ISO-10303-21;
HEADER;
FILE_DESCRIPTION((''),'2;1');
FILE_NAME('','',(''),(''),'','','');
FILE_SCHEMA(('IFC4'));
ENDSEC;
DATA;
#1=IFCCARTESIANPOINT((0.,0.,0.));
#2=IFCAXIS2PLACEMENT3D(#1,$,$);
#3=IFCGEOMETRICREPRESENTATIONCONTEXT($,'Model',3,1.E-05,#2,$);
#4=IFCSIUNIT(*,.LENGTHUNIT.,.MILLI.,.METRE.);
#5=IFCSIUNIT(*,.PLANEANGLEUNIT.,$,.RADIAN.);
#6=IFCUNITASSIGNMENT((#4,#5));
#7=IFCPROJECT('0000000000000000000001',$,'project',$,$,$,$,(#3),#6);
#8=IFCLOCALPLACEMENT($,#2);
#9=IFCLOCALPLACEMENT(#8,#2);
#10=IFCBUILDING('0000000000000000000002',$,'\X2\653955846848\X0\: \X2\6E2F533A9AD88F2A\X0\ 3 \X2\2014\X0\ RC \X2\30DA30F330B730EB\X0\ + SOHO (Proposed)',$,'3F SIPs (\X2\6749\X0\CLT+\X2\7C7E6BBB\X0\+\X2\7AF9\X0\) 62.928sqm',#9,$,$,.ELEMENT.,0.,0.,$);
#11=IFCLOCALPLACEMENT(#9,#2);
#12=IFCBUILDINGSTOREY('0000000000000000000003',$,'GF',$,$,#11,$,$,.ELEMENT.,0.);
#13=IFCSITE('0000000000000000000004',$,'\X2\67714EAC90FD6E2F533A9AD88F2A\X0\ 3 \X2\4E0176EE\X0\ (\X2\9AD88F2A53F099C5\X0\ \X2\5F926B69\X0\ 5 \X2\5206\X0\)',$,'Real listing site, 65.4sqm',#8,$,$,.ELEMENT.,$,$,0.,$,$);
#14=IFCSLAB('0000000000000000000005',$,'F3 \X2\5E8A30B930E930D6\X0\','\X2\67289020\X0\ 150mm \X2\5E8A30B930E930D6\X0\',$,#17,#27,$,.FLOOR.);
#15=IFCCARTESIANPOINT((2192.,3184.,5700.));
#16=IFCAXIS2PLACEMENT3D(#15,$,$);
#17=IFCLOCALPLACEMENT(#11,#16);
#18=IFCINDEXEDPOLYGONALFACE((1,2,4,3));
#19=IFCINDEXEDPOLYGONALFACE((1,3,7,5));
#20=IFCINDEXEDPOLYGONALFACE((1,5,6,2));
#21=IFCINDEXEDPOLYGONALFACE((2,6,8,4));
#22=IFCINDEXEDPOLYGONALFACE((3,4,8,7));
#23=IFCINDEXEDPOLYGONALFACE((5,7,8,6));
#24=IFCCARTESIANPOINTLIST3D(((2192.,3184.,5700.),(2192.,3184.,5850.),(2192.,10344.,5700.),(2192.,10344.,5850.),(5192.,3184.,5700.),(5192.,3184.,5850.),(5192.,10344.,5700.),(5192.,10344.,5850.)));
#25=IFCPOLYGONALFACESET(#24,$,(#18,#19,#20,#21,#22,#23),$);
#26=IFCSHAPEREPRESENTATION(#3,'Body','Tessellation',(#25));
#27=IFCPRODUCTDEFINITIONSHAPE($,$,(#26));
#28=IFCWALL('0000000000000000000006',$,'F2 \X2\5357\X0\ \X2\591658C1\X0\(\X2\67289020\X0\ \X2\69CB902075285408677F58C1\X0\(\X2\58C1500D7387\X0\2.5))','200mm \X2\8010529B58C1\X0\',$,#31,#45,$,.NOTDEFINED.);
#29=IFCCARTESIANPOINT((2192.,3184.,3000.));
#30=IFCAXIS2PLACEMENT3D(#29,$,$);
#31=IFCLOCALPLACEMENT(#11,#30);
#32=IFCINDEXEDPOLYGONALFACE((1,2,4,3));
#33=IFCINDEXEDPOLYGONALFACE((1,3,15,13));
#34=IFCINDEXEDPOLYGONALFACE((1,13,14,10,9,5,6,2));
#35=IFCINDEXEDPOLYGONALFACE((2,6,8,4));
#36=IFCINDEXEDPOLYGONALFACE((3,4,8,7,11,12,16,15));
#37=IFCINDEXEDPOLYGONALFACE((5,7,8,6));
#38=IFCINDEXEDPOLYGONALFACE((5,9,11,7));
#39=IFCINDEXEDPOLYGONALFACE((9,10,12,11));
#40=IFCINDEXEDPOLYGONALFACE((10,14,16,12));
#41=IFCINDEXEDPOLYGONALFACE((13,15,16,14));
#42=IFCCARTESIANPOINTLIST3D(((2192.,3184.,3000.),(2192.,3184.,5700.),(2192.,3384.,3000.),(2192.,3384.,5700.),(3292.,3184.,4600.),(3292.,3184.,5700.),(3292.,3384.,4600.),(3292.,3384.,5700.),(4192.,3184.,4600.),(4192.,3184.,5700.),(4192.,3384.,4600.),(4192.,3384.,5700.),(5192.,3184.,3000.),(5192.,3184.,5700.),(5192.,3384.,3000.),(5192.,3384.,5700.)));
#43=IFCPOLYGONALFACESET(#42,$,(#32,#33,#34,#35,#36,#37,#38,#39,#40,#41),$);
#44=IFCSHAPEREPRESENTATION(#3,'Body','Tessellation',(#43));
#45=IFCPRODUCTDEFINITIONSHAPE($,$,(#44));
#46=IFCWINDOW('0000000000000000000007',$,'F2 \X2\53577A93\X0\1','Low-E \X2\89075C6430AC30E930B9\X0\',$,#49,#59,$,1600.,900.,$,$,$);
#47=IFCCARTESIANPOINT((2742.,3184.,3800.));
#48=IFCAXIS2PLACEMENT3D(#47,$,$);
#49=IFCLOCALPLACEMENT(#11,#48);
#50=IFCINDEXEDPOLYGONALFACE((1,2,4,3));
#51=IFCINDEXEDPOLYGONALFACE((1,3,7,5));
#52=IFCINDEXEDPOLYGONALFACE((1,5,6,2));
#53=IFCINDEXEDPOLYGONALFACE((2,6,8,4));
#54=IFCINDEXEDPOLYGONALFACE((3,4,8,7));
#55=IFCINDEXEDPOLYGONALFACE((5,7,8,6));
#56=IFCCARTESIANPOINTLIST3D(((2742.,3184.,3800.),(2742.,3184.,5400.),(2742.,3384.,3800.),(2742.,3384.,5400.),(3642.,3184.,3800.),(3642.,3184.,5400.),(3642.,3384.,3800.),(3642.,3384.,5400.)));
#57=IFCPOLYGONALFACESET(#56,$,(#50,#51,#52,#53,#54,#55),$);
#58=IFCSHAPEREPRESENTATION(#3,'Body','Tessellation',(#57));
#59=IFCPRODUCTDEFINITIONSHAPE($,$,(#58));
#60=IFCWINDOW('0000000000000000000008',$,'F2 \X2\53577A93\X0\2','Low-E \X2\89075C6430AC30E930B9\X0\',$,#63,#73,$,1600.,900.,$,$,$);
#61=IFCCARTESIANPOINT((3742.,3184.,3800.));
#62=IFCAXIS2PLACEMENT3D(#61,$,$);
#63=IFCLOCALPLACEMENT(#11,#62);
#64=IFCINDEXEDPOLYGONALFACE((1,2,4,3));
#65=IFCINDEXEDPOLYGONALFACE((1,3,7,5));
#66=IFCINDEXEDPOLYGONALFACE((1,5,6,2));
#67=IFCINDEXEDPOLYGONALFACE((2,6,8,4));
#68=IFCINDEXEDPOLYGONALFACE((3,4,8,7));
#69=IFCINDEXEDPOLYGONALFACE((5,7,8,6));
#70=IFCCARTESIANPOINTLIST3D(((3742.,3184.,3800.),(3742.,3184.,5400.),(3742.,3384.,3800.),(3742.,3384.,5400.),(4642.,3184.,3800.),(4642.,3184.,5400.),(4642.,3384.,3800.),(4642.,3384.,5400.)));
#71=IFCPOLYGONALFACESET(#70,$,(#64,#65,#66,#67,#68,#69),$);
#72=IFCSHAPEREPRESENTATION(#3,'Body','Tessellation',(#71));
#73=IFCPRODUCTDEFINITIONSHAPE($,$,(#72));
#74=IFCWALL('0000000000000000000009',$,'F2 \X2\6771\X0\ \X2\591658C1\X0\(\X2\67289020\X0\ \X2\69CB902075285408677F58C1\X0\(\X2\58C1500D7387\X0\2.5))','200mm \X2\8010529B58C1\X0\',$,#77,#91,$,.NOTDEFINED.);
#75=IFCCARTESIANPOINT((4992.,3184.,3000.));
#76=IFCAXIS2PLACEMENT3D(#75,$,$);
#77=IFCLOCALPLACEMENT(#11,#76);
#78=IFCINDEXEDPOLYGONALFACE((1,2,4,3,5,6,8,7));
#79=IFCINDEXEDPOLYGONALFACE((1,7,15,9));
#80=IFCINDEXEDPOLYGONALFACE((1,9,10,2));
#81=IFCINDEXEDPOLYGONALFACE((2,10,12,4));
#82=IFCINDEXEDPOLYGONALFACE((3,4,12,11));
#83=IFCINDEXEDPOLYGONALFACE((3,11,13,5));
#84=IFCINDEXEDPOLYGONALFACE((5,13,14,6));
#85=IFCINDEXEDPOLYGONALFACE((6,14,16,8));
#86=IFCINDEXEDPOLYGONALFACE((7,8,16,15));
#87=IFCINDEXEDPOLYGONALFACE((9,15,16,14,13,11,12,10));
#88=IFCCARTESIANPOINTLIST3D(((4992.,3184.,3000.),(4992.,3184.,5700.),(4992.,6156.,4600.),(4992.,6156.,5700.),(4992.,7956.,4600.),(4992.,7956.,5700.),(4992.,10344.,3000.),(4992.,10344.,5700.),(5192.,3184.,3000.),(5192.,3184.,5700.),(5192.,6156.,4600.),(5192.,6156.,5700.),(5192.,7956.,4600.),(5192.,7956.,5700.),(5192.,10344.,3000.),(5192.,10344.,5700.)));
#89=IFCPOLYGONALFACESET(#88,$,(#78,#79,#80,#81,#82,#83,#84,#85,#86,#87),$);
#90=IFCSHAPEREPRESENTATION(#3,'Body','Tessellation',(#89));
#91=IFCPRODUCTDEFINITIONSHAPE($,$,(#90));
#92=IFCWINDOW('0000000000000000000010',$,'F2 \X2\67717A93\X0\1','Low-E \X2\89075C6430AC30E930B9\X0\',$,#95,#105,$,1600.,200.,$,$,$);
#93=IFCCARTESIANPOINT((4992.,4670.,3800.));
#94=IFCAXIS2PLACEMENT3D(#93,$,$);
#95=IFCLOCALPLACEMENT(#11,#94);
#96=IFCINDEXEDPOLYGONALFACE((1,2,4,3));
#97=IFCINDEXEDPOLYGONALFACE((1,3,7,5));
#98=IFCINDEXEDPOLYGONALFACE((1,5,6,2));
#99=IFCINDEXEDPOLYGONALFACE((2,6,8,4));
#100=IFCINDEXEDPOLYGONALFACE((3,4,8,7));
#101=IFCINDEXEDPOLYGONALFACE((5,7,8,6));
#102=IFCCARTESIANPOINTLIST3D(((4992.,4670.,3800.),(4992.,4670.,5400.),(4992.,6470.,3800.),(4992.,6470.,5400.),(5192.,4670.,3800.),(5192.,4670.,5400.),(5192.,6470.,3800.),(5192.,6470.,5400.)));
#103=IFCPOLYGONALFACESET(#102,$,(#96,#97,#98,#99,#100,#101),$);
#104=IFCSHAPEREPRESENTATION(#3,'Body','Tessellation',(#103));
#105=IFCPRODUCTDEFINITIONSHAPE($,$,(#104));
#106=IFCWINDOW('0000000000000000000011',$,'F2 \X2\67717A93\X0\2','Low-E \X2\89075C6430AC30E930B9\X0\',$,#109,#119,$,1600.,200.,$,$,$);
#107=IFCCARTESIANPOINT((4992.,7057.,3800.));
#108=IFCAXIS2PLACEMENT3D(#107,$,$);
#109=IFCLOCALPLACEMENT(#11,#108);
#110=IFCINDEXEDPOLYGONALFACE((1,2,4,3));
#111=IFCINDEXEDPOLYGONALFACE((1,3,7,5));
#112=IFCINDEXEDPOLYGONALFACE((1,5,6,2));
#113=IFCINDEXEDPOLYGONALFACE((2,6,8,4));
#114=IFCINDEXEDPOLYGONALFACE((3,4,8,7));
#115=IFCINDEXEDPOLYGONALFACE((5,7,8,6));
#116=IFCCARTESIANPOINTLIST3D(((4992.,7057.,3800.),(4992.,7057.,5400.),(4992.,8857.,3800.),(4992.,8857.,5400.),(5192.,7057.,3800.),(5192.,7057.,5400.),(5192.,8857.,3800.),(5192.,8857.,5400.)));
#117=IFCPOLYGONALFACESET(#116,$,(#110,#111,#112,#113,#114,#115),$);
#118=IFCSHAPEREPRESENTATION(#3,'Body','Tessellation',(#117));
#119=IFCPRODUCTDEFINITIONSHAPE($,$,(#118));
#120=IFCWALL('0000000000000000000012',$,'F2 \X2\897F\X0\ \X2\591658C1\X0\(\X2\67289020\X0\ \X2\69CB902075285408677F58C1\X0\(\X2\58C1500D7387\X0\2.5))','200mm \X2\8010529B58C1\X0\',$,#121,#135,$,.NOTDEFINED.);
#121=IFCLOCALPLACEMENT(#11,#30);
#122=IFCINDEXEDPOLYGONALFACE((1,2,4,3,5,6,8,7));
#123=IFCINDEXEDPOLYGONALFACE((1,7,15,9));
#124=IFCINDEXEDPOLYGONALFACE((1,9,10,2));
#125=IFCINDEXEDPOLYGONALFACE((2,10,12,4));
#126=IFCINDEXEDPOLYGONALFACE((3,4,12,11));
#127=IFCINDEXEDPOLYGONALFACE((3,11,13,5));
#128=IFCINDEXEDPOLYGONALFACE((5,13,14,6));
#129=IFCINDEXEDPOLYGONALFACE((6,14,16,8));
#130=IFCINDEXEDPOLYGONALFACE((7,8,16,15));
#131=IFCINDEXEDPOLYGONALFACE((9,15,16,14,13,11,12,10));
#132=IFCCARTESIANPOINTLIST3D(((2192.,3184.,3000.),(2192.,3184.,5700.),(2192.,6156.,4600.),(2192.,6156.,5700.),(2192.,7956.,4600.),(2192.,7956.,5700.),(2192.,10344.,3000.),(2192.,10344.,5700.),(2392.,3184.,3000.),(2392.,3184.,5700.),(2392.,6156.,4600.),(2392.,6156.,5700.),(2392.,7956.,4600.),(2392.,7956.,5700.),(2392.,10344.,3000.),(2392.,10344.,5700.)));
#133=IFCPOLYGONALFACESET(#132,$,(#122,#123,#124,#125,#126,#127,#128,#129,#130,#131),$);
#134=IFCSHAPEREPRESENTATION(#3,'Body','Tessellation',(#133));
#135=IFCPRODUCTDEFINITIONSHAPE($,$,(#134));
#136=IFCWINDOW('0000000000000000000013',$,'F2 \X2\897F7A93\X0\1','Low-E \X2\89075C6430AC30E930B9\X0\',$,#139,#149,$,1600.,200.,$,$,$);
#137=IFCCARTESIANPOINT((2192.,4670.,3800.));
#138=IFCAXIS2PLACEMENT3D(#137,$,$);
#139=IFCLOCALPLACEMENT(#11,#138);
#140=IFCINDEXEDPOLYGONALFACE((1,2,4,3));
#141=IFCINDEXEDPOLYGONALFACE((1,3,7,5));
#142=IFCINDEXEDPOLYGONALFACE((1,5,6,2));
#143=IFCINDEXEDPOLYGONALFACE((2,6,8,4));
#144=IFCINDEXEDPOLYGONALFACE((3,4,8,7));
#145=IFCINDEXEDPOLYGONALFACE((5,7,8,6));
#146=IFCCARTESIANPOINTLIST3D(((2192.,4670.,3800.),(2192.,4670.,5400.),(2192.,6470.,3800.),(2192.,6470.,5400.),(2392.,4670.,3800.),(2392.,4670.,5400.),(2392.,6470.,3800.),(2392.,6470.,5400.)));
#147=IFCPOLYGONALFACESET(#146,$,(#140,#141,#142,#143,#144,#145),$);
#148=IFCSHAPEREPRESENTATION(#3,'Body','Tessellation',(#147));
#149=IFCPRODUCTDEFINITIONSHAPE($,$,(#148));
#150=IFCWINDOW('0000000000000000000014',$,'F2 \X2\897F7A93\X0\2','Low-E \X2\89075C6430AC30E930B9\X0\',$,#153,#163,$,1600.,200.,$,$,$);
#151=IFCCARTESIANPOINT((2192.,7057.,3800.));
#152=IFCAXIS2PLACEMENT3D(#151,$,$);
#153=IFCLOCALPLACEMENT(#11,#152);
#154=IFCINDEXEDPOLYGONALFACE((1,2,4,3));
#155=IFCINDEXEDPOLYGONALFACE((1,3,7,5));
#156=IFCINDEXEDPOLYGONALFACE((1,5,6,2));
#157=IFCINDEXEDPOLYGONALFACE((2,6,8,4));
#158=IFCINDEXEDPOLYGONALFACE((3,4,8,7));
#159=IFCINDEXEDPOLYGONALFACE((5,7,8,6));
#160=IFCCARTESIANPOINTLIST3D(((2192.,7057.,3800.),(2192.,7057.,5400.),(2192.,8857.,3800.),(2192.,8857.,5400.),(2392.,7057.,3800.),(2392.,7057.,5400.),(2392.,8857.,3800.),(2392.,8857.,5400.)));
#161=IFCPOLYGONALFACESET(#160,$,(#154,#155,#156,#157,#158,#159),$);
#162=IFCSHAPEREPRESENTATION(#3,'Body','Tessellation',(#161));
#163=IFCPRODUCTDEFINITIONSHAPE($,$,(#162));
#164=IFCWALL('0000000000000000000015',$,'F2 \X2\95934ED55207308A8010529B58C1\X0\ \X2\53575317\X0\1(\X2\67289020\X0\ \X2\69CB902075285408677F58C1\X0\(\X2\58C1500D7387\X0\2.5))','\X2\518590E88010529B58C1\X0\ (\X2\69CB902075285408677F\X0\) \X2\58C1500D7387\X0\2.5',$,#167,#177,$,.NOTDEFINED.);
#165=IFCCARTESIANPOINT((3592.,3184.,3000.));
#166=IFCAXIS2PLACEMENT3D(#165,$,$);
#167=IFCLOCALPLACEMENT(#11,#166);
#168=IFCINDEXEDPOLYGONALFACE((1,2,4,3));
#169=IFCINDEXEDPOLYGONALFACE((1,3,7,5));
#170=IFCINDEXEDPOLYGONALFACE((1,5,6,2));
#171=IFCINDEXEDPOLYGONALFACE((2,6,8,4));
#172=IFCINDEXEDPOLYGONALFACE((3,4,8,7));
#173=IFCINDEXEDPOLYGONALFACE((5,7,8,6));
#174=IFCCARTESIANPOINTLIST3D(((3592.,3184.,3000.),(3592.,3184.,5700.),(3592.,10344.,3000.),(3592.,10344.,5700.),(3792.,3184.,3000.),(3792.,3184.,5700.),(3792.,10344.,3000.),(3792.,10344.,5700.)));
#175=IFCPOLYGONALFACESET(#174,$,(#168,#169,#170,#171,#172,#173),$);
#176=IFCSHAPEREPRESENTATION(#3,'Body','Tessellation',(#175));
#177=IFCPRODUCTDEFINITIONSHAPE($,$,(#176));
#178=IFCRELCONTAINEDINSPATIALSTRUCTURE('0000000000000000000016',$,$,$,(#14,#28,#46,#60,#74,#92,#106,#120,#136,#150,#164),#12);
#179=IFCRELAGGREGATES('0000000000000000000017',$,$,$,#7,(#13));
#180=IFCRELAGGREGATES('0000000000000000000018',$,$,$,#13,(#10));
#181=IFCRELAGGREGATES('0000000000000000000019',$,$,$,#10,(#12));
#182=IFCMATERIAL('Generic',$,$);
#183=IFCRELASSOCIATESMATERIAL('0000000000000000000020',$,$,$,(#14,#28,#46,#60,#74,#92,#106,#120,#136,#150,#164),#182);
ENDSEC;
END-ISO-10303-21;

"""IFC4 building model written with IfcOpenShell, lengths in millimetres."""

from ifc_helpers import new_model, si_unit, frame, frame_2d, origin, place, context, project, spatial, rectangle, extrude, material, element, fill, save


model = new_model("IFC4")

# Units and contexts
model_context = context("Model", 3, precision=1e-05, world=origin())
ifc_project = project(units=[si_unit("LENGTHUNIT", "METRE", prefix="MILLI"), si_unit("PLANEANGLEUNIT", "RADIAN")], contexts=[model_context])

# Site, building, storey
site_placement = place(None, origin())
site = spatial("IfcSite", under=ifc_project, at=site_placement, Name="東京都港区高輪 3 丁目 (高輪台駅 徒歩 5 分)", ObjectType="Real listing site, 65.4sqm", CompositionType="ELEMENT", RefElevation=0.0)
building_placement = place(site_placement, origin())
building = spatial("IfcBuilding", under=site, at=building_placement, Name="改善案: 港区高輪 3 — RC ペンシル + SOHO (Proposed)", ObjectType="3F SIPs (杉CLT+籾殻+竹) 62.928sqm", CompositionType="ELEMENT", ElevationOfRefHeight=0.0, ElevationOfTerrain=0.0)
storey_placement = place(building_placement, origin())
storey = spatial("IfcBuildingStorey", under=building, at=storey_placement, Name="GF", CompositionType="ELEMENT", Elevation=0.0)

# Slab
ifc_material = material(Name="Generic")
slab_placement = place(storey_placement, frame((2192.0, 3184.0, 5700.0)))
element("IfcSlab", 1, at=slab_placement, inside=storey, material=ifc_material, Name="F3 床スラブ", Description="木造 150mm 床スラブ", PredefinedType="FLOOR", context=model_context, shape_type="SweptSolid", body=[
    extrude(rectangle(XDim=3000.0, YDim=7160.0, at=frame_2d((1500.0, 3580.0))), frame((2192.0, 3184.0, 5700.0)), (0.0, 0.0, 1.0), 150.0),
])

# Walls, openings, windows
wall_1_placement = place(storey_placement, frame((2192.0, 3184.0, 3000.0)))
wall_1 = element("IfcWall", 2, at=wall_1_placement, inside=storey, material=ifc_material, Name="F2 南 外壁(木造 構造用合板壁(壁倍率2.5))", Description="200mm 耐力壁", PredefinedType="NOTDEFINED", context=model_context, shape_type="SweptSolid", body=[
    extrude(rectangle(XDim=3000.0, YDim=200.0, at=frame_2d((1500.0, 100.0))), frame((2192.0, 3184.0, 3000.0)), (0.0, 0.0, 1.0), 2700.0),
])
opening_1_placement = place(storey_placement, frame((2742.0, 3184.0, 3800.0)))
opening_1 = element("IfcOpeningElement", 3, at=opening_1_placement, cuts=wall_1, PredefinedType="NOTDEFINED", context=model_context, shape_type="SweptSolid", body=[
    extrude(rectangle(XDim=900.0, YDim=200.0, at=frame_2d((450.0, 100.0))), frame((2742.0, 3184.0, 3800.0)), (0.0, 0.0, 1.0), 1600.0),
])
opening_2_placement = place(storey_placement, frame((3742.0, 3184.0, 3800.0)))
opening_2 = element("IfcOpeningElement", 4, at=opening_2_placement, cuts=wall_1, PredefinedType="NOTDEFINED", context=model_context, shape_type="SweptSolid", body=[
    extrude(rectangle(XDim=900.0, YDim=200.0, at=frame_2d((450.0, 100.0))), frame((3742.0, 3184.0, 3800.0)), (0.0, 0.0, 1.0), 1600.0),
])
window_1_placement = place(storey_placement, frame((2742.0, 3184.0, 3800.0)))
window_1 = element("IfcWindow", 5, at=window_1_placement, inside=storey, material=ifc_material, Name="F2 南窓1", Description="Low-E 複層ガラス", OverallHeight=1600.0, OverallWidth=900.0, context=model_context, shape_type="SweptSolid", body=[
    extrude(rectangle(XDim=900.0, YDim=200.0, at=frame_2d((450.0, 100.0))), frame((2742.0, 3184.0, 3800.0)), (0.0, 0.0, 1.0), 1600.0),
])
fill(opening_1, window_1)
window_2_placement = place(storey_placement, frame((3742.0, 3184.0, 3800.0)))
window_2 = element("IfcWindow", 6, at=window_2_placement, inside=storey, material=ifc_material, Name="F2 南窓2", Description="Low-E 複層ガラス", OverallHeight=1600.0, OverallWidth=900.0, context=model_context, shape_type="SweptSolid", body=[
    extrude(rectangle(XDim=900.0, YDim=200.0, at=frame_2d((450.0, 100.0))), frame((3742.0, 3184.0, 3800.0)), (0.0, 0.0, 1.0), 1600.0),
])
fill(opening_2, window_2)
wall_2_placement = place(storey_placement, frame((4992.0, 3184.0, 3000.0)))
wall_2 = element("IfcWall", 7, at=wall_2_placement, inside=storey, material=ifc_material, Name="F2 東 外壁(木造 構造用合板壁(壁倍率2.5))", Description="200mm 耐力壁", PredefinedType="NOTDEFINED", context=model_context, shape_type="SweptSolid", body=[
    extrude(rectangle(XDim=200.0, YDim=7160.0, at=frame_2d((100.0, 3580.0))), frame((4992.0, 3184.0, 3000.0)), (0.0, 0.0, 1.0), 2700.0),
])
opening_3_placement = place(storey_placement, frame((4992.0, 4670.0, 3800.0)))
opening_3 = element("IfcOpeningElement", 8, at=opening_3_placement, cuts=wall_2, PredefinedType="NOTDEFINED", context=model_context, shape_type="SweptSolid", body=[
    extrude(rectangle(XDim=200.0, YDim=1800.0, at=frame_2d((100.0, 900.0))), frame((4992.0, 4670.0, 3800.0)), (0.0, 0.0, 1.0), 1600.0),
])
opening_4_placement = place(storey_placement, frame((4992.0, 7057.0, 3800.0)))
opening_4 = element("IfcOpeningElement", 9, at=opening_4_placement, cuts=wall_2, PredefinedType="NOTDEFINED", context=model_context, shape_type="SweptSolid", body=[
    extrude(rectangle(XDim=200.0, YDim=1800.0, at=frame_2d((100.0, 900.0))), frame((4992.0, 7057.0, 3800.0)), (0.0, 0.0, 1.0), 1600.0),
])
window_3_placement = place(storey_placement, frame((4992.0, 4670.0, 3800.0)))
window_3 = element("IfcWindow", 10, at=window_3_placement, inside=storey, material=ifc_material, Name="F2 東窓1", Description="Low-E 複層ガラス", OverallHeight=1600.0, OverallWidth=200.0, context=model_context, shape_type="SweptSolid", body=[
    extrude(rectangle(XDim=200.0, YDim=1800.0, at=frame_2d((100.0, 900.0))), frame((4992.0, 4670.0, 3800.0)), (0.0, 0.0, 1.0), 1600.0),
])
fill(opening_3, window_3)
window_4_placement = place(storey_placement, frame((4992.0, 7057.0, 3800.0)))
window_4 = element("IfcWindow", 11, at=window_4_placement, inside=storey, material=ifc_material, Name="F2 東窓2", Description="Low-E 複層ガラス", OverallHeight=1600.0, OverallWidth=200.0, context=model_context, shape_type="SweptSolid", body=[
    extrude(rectangle(XDim=200.0, YDim=1800.0, at=frame_2d((100.0, 900.0))), frame((4992.0, 7057.0, 3800.0)), (0.0, 0.0, 1.0), 1600.0),
])
fill(opening_4, window_4)
wall_3_placement = place(storey_placement, frame((2192.0, 3184.0, 3000.0)))
wall_3 = element("IfcWall", 12, at=wall_3_placement, inside=storey, material=ifc_material, Name="F2 西 外壁(木造 構造用合板壁(壁倍率2.5))", Description="200mm 耐力壁", PredefinedType="NOTDEFINED", context=model_context, shape_type="SweptSolid", body=[
    extrude(rectangle(XDim=200.0, YDim=7160.0, at=frame_2d((100.0, 3580.0))), frame((2192.0, 3184.0, 3000.0)), (0.0, 0.0, 1.0), 2700.0),
])
opening_5_placement = place(storey_placement, frame((2192.0, 4670.0, 3800.0)))
opening_5 = element("IfcOpeningElement", 13, at=opening_5_placement, cuts=wall_3, PredefinedType="NOTDEFINED", context=model_context, shape_type="SweptSolid", body=[
    extrude(rectangle(XDim=200.0, YDim=1800.0, at=frame_2d((100.0, 900.0))), frame((2192.0, 4670.0, 3800.0)), (0.0, 0.0, 1.0), 1600.0),
])
opening_6_placement = place(storey_placement, frame((2192.0, 7057.0, 3800.0)))
opening_6 = element("IfcOpeningElement", 14, at=opening_6_placement, cuts=wall_3, PredefinedType="NOTDEFINED", context=model_context, shape_type="SweptSolid", body=[
    extrude(rectangle(XDim=200.0, YDim=1800.0, at=frame_2d((100.0, 900.0))), frame((2192.0, 7057.0, 3800.0)), (0.0, 0.0, 1.0), 1600.0),
])
window_5_placement = place(storey_placement, frame((2192.0, 4670.0, 3800.0)))
window_5 = element("IfcWindow", 15, at=window_5_placement, inside=storey, material=ifc_material, Name="F2 西窓1", Description="Low-E 複層ガラス", OverallHeight=1600.0, OverallWidth=200.0, context=model_context, shape_type="SweptSolid", body=[
    extrude(rectangle(XDim=200.0, YDim=1800.0, at=frame_2d((100.0, 900.0))), frame((2192.0, 4670.0, 3800.0)), (0.0, 0.0, 1.0), 1600.0),
])
fill(opening_5, window_5)
window_6_placement = place(storey_placement, frame((2192.0, 7057.0, 3800.0)))
window_6 = element("IfcWindow", 16, at=window_6_placement, inside=storey, material=ifc_material, Name="F2 西窓2", Description="Low-E 複層ガラス", OverallHeight=1600.0, OverallWidth=200.0, context=model_context, shape_type="SweptSolid", body=[
    extrude(rectangle(XDim=200.0, YDim=1800.0, at=frame_2d((100.0, 900.0))), frame((2192.0, 7057.0, 3800.0)), (0.0, 0.0, 1.0), 1600.0),
])
fill(opening_6, window_6)

# Wall
wall_4_placement = place(storey_placement, frame((3592.0, 3184.0, 3000.0)))
element("IfcWall", 17, at=wall_4_placement, inside=storey, material=ifc_material, Name="F2 間仕切り耐力壁 南北1(木造 構造用合板壁(壁倍率2.5))", Description="内部耐力壁 (構造用合板) 壁倍率2.5", PredefinedType="NOTDEFINED", context=model_context, shape_type="SweptSolid", body=[
    extrude(rectangle(XDim=200.0, YDim=7160.0, at=frame_2d((100.0, 3580.0))), frame((3592.0, 3184.0, 3000.0)), (0.0, 0.0, 1.0), 2700.0),
])

save(model, "model.ifc")
